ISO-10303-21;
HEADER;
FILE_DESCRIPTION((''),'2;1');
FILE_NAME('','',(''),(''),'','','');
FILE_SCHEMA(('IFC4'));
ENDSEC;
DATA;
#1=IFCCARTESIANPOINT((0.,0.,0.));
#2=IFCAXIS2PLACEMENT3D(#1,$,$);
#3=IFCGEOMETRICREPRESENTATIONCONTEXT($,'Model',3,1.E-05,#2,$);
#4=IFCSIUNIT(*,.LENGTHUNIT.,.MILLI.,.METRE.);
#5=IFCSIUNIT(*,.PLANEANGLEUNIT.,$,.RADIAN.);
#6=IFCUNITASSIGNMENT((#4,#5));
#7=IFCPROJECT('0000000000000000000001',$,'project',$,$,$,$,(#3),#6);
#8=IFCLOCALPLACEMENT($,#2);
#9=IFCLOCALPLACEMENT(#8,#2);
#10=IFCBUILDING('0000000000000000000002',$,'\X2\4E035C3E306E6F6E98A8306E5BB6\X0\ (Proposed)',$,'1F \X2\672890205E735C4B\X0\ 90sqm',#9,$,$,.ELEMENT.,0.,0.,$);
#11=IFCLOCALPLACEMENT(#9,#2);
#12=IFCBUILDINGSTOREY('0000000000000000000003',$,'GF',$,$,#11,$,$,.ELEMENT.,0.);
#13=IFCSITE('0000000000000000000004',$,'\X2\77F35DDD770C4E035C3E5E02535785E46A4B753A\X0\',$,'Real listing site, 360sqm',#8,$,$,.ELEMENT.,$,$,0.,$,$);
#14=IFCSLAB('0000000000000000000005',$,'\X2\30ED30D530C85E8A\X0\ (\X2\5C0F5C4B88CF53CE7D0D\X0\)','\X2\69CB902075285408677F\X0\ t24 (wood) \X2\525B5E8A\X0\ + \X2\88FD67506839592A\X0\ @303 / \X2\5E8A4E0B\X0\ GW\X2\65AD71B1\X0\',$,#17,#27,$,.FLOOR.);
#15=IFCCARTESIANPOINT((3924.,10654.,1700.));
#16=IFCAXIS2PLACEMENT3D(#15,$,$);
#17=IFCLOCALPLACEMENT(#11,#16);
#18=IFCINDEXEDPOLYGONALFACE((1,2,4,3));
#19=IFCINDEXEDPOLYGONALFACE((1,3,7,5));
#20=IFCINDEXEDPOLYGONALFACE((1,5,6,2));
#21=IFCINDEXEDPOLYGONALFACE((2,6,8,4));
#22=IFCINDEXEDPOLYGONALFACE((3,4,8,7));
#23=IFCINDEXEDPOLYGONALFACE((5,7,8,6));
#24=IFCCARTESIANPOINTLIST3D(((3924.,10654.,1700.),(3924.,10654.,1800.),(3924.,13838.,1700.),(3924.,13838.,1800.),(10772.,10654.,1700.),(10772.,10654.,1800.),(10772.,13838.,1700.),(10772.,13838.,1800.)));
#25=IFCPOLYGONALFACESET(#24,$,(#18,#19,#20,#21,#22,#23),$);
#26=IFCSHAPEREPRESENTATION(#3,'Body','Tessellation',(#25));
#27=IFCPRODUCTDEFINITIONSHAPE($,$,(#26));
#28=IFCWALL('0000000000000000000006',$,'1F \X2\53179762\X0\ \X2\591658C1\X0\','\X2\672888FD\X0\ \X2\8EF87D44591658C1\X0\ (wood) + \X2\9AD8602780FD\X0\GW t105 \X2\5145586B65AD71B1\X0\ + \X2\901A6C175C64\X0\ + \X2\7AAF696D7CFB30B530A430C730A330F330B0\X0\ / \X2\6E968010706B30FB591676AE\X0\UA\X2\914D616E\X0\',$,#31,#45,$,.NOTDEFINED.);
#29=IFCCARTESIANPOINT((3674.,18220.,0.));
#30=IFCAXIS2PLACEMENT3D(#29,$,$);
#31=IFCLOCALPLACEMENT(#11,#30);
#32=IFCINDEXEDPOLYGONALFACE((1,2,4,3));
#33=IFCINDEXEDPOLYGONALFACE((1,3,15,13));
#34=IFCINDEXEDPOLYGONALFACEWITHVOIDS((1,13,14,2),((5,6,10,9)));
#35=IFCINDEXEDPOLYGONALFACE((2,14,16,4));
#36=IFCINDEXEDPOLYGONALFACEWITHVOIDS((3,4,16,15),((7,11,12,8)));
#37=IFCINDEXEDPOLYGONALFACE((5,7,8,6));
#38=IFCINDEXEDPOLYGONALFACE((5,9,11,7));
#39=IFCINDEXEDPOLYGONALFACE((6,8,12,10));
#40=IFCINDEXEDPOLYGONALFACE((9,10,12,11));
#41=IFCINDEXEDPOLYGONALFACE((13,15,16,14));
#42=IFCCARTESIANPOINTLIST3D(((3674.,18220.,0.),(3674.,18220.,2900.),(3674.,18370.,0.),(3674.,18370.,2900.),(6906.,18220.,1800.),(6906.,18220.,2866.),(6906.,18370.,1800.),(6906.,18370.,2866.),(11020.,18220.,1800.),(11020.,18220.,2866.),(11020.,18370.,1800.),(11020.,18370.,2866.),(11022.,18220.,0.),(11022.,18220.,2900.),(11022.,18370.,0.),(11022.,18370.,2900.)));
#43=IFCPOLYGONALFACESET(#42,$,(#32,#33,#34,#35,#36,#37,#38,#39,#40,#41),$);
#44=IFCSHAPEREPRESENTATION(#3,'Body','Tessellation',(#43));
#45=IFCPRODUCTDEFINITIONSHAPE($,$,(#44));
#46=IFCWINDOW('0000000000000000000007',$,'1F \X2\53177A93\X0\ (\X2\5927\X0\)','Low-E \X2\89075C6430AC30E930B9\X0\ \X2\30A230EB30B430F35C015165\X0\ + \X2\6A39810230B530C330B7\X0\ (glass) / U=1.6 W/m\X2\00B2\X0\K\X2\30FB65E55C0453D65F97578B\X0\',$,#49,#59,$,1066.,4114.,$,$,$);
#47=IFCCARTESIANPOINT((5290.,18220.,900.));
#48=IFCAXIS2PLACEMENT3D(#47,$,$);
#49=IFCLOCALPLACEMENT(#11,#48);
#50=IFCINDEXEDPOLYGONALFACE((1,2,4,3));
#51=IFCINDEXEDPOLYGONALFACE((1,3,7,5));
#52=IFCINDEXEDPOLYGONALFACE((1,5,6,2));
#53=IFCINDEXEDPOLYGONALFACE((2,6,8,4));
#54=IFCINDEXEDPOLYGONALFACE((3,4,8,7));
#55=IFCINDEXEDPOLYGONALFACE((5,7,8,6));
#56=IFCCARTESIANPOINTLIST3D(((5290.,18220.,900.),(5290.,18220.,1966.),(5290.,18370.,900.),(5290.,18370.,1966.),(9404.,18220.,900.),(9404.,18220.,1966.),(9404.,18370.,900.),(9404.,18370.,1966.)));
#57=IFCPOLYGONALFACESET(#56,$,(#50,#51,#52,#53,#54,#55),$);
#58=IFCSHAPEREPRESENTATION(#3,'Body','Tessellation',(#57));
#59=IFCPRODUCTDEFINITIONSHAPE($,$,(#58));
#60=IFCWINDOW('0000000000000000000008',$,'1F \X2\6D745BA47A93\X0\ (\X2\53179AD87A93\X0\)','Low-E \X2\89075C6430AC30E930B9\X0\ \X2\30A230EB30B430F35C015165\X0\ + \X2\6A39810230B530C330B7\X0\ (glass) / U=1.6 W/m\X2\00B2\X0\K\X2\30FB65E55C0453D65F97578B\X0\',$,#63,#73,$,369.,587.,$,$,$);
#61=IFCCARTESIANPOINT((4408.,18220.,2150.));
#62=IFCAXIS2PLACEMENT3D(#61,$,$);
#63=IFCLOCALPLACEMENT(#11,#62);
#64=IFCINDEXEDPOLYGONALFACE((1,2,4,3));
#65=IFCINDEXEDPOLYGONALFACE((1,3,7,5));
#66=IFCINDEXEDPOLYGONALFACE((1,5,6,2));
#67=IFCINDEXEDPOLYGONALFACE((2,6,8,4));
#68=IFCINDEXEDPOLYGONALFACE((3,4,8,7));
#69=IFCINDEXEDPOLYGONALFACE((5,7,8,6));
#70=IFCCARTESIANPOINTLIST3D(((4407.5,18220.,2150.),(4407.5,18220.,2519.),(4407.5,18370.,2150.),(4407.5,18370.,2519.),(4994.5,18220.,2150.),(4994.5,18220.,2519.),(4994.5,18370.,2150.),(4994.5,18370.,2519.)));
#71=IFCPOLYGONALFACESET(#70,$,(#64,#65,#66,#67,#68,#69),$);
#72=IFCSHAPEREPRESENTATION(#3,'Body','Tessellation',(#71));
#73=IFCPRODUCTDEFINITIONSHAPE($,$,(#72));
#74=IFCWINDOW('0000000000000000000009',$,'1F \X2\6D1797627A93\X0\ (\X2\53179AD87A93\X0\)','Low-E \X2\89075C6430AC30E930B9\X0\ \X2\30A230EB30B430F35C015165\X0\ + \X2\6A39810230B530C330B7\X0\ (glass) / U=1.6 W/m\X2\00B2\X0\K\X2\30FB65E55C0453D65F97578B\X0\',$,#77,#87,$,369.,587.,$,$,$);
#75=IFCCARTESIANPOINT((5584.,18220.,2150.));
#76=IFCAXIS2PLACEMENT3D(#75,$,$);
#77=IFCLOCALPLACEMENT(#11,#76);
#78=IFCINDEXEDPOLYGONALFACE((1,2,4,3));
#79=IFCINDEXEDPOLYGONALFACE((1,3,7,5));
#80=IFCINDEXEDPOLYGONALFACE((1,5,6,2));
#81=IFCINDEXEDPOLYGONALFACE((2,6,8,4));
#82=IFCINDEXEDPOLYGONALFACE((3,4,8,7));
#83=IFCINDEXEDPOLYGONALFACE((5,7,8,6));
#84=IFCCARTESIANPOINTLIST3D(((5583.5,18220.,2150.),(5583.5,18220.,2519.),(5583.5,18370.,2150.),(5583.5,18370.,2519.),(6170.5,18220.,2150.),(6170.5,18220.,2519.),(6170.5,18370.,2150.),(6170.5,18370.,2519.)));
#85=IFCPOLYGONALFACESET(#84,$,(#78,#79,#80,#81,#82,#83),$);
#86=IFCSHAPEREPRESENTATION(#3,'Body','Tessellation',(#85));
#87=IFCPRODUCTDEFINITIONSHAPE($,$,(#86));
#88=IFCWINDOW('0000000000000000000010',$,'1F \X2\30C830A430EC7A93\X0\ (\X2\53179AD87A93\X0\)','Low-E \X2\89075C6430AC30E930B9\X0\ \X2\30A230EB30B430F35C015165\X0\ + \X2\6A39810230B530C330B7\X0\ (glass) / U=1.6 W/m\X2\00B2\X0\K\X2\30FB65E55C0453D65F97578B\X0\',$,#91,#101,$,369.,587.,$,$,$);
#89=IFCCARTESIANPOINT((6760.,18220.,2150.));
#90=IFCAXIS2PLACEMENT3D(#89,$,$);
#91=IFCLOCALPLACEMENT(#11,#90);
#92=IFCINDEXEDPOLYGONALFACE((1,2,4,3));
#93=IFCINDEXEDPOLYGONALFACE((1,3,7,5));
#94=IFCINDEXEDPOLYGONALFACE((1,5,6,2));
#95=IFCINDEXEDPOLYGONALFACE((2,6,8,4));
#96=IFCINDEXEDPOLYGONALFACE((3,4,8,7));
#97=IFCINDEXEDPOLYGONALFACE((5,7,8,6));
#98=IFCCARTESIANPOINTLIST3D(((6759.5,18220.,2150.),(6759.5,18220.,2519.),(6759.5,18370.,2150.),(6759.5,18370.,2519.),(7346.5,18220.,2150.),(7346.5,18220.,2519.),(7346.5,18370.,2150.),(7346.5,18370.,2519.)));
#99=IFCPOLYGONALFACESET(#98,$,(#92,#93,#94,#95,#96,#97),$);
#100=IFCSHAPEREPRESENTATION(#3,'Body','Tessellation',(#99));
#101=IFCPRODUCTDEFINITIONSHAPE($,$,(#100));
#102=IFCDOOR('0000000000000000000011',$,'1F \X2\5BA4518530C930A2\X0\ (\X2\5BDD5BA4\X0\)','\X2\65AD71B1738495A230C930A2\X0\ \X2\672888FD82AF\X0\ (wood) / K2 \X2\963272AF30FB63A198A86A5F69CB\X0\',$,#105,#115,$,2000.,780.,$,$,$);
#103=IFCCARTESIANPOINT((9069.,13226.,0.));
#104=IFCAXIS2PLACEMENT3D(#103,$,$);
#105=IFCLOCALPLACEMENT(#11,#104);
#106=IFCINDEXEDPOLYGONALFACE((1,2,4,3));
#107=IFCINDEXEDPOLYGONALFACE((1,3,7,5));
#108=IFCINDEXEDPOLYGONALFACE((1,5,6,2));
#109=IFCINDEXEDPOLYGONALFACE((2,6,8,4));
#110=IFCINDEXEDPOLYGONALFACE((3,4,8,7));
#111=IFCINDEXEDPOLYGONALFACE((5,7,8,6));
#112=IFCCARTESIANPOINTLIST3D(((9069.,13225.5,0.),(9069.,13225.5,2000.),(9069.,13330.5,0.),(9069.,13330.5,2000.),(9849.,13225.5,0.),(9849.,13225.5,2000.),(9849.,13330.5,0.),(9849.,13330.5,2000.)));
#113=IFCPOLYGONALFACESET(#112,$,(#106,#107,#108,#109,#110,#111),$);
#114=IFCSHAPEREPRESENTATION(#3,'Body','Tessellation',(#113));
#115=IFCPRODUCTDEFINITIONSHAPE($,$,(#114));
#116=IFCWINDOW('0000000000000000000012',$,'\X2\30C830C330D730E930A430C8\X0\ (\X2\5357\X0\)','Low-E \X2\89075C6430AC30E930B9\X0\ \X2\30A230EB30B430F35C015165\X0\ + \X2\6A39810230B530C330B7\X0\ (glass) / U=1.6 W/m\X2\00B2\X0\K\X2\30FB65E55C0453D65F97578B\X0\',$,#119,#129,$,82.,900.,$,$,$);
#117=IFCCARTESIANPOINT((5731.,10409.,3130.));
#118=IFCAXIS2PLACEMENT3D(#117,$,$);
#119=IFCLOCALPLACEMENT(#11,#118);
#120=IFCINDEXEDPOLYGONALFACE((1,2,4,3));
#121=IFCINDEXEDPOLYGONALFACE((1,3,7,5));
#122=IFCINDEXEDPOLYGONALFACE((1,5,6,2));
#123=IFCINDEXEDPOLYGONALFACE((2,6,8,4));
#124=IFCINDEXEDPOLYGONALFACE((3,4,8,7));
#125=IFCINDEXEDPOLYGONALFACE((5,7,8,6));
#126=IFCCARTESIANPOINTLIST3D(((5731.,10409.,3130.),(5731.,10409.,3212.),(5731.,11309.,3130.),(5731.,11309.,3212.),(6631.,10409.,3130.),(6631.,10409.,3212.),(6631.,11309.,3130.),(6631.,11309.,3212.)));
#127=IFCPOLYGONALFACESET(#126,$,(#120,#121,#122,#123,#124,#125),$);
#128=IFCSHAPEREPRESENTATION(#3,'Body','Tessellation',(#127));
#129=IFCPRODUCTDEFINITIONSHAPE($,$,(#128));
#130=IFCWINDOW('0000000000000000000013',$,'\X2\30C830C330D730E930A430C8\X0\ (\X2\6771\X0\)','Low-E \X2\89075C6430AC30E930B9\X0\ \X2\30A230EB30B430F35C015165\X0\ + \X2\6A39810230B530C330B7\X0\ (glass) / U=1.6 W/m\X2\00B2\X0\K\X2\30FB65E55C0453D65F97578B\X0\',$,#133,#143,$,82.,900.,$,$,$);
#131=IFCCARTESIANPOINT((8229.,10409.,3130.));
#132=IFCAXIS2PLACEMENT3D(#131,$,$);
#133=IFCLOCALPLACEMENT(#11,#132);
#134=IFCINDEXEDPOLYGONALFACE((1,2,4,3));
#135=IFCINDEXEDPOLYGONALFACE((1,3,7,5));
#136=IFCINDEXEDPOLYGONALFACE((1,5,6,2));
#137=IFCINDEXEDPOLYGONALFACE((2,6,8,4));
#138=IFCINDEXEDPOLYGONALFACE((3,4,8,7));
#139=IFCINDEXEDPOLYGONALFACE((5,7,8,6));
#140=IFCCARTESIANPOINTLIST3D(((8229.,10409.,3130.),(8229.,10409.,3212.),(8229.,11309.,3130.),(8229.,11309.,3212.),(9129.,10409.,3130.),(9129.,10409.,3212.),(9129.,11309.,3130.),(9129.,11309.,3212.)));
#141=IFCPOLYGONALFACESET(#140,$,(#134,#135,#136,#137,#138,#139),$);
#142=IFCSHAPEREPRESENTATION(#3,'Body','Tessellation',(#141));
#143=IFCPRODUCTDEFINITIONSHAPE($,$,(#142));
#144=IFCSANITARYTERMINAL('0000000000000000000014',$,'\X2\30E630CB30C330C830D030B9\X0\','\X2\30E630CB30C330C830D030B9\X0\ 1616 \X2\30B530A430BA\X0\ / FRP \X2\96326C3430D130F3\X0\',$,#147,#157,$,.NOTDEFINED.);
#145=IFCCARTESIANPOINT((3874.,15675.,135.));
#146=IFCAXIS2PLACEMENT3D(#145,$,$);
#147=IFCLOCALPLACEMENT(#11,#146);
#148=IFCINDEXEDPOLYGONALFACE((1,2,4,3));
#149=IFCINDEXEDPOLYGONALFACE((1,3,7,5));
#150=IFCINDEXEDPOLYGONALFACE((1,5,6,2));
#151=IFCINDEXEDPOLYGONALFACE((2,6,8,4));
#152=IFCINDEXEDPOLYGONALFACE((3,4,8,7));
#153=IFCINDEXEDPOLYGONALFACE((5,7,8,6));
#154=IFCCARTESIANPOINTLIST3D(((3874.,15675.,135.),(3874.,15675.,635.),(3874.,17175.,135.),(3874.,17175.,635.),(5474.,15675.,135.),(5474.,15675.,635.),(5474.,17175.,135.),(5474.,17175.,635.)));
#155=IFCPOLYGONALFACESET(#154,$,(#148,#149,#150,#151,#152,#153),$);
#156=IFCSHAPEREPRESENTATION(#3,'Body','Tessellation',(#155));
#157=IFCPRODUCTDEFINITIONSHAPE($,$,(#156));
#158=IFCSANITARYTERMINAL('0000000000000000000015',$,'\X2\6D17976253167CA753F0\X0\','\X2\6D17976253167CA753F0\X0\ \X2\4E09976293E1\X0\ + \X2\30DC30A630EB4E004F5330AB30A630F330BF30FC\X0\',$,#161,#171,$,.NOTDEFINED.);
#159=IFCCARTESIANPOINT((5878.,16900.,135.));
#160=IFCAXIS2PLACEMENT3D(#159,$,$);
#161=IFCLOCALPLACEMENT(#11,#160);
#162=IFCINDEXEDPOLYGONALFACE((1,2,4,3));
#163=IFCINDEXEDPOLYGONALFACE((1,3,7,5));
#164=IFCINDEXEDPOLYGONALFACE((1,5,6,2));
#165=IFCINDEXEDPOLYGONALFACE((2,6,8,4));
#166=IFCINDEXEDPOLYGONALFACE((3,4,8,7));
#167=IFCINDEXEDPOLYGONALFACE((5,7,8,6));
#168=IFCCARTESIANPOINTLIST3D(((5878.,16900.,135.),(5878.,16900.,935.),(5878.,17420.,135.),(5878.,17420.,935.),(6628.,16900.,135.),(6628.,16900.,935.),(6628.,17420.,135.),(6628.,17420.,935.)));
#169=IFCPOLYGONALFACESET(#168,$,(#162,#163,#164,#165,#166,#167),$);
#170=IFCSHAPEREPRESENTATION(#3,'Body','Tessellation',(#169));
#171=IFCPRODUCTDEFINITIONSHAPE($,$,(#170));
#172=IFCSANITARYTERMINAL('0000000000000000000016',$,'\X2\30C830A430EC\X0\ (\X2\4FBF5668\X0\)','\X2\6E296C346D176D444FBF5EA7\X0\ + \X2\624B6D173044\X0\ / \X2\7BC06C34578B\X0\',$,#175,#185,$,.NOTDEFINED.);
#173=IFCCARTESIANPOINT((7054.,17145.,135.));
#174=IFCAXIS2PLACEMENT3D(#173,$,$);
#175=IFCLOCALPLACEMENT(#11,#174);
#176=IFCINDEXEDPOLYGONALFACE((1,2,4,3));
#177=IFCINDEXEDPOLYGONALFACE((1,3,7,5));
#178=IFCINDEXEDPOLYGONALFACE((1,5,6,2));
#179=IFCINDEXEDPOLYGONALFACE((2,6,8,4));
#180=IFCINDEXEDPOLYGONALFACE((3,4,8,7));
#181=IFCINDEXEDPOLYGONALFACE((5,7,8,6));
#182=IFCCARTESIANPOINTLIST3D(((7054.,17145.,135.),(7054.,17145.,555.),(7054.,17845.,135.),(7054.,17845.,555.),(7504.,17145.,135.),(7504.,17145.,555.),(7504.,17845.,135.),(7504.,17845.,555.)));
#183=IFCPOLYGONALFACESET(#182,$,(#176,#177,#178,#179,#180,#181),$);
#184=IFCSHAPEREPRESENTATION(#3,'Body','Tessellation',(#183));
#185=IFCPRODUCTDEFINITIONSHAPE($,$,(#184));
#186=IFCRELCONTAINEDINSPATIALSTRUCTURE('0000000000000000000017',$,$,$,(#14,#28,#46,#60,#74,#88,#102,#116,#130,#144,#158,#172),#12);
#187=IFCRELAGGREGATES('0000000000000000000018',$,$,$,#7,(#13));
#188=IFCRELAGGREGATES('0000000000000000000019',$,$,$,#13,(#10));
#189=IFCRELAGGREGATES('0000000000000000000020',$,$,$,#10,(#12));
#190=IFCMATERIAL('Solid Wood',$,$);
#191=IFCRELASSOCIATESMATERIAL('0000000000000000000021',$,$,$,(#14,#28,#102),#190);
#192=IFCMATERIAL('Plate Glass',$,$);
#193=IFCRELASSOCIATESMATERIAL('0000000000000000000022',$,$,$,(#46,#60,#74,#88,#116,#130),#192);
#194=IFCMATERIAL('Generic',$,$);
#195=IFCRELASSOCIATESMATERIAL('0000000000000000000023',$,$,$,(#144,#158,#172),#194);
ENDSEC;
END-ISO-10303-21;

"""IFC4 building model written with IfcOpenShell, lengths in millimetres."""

from ifc_helpers import new_model, si_unit, frame, frame_2d, origin, place, context, project, spatial, rectangle, extrude, material, element, fill, save


model = new_model("IFC4")

# Units and contexts
model_context = context("Model", 3, precision=1e-05, world=origin())
ifc_project = project(units=[si_unit("LENGTHUNIT", "METRE", prefix="MILLI"), si_unit("PLANEANGLEUNIT", "RADIAN")], contexts=[model_context])

# Site, building, storey
site_placement = place(None, origin())
site = spatial("IfcSite", under=ifc_project, at=site_placement, Name="石川県七尾市南藤橋町", ObjectType="Real listing site, 360sqm", CompositionType="ELEMENT", RefElevation=0.0)
building_placement = place(site_placement, origin())
building = spatial("IfcBuilding", under=site, at=building_placement, Name="七尾の潮風の家 (Proposed)", ObjectType="1F 木造平屋 90sqm", CompositionType="ELEMENT", ElevationOfRefHeight=0.0, ElevationOfTerrain=0.0)
storey_placement = place(building_placement, origin())
storey = spatial("IfcBuildingStorey", under=building, at=storey_placement, Name="GF", CompositionType="ELEMENT", Elevation=0.0)

# Slab
ifc_material_1 = material(Name="Solid Wood")
slab_placement = place(storey_placement, frame((3924.0, 10654.0, 1700.0)))
element("IfcSlab", 1, at=slab_placement, inside=storey, material=ifc_material_1, Name="ロフト床 (小屋裏収納)", Description="構造用合板 t24 (wood) 剛床 + 製材根太 @303 / 床下 GW断熱", PredefinedType="FLOOR", context=model_context, shape_type="SweptSolid", body=[
    extrude(rectangle(XDim=6848.0, YDim=3184.0, at=frame_2d((3424.0, 1592.0))), frame((3924.0, 10654.0, 1700.0)), (0.0, 0.0, 1.0), 100.0),
])

# Wall, openings, windows
wall_1_placement = place(storey_placement, frame((3674.0, 18220.0, 0.0)))
wall_1 = element("IfcWall", 2, at=wall_1_placement, inside=storey, material=ifc_material_1, Name="1F 北面 外壁", Description="木製 軸組外壁 (wood) + 高性能GW t105 充填断熱 + 通気層 + 窯業系サイディング / 準耐火・外皮UA配慮", PredefinedType="NOTDEFINED", context=model_context, shape_type="SweptSolid", body=[
    extrude(rectangle(XDim=7348.0, YDim=150.0, at=frame_2d((3674.0, 75.0))), frame((3674.0, 18220.0, 0.0)), (0.0, 0.0, 1.0), 2900.0),
])
opening_1_placement = place(storey_placement, frame((5290.0, 18220.0, 900.0)))
opening_1 = element("IfcOpeningElement", 3, at=opening_1_placement, cuts=wall_1, PredefinedType="NOTDEFINED", context=model_context, shape_type="SweptSolid", body=[
    extrude(rectangle(XDim=4114.0, YDim=150.0, at=frame_2d((2057.0, 75.0))), frame((5290.0, 18220.0, 900.0)), (0.0, 0.0, 1.0), 1066.0),
])
opening_2_placement = place(storey_placement, frame((4408.0, 18220.0, 2150.0)))
opening_2 = element("IfcOpeningElement", 4, at=opening_2_placement, cuts=wall_1, PredefinedType="NOTDEFINED", context=model_context, shape_type="SweptSolid", body=[
    extrude(rectangle(XDim=587.0, YDim=150.0, at=frame_2d((293.0, 75.0))), frame((4408.0, 18220.0, 2150.0)), (0.0, 0.0, 1.0), 369.0),
])
opening_3_placement = place(storey_placement, frame((5584.0, 18220.0, 2150.0)))
opening_3 = element("IfcOpeningElement", 5, at=opening_3_placement, cuts=wall_1, PredefinedType="NOTDEFINED", context=model_context, shape_type="SweptSolid", body=[
    extrude(rectangle(XDim=587.0, YDim=150.0, at=frame_2d((293.0, 75.0))), frame((5584.0, 18220.0, 2150.0)), (0.0, 0.0, 1.0), 369.0),
])
opening_4_placement = place(storey_placement, frame((6760.0, 18220.0, 2150.0)))
opening_4 = element("IfcOpeningElement", 6, at=opening_4_placement, cuts=wall_1, PredefinedType="NOTDEFINED", context=model_context, shape_type="SweptSolid", body=[
    extrude(rectangle(XDim=587.0, YDim=150.0, at=frame_2d((293.0, 75.0))), frame((6760.0, 18220.0, 2150.0)), (0.0, 0.0, 1.0), 369.0),
])
ifc_material_2 = material(Name="Plate Glass")
window_1_placement = place(storey_placement, frame((5290.0, 18220.0, 900.0)))
window_1 = element("IfcWindow", 7, at=window_1_placement, inside=storey, material=ifc_material_2, Name="1F 北窓 (大)", Description="Low-E 複層ガラス アルゴン封入 + 樹脂サッシ (glass) / U=1.6 W/m²K・日射取得型", OverallHeight=1066.0, OverallWidth=4114.0, context=model_context, shape_type="SweptSolid", body=[
    extrude(rectangle(XDim=4114.0, YDim=150.0, at=frame_2d((2057.0, 75.0))), frame((5290.0, 18220.0, 900.0)), (0.0, 0.0, 1.0), 1066.0),
])
fill(opening_1, window_1)
window_2_placement = place(storey_placement, frame((4408.0, 18220.0, 2150.0)))
window_2 = element("IfcWindow", 8, at=window_2_placement, inside=storey, material=ifc_material_2, Name="1F 浴室窓 (北高窓)", Description="Low-E 複層ガラス アルゴン封入 + 樹脂サッシ (glass) / U=1.6 W/m²K・日射取得型", OverallHeight=369.0, OverallWidth=587.0, context=model_context, shape_type="SweptSolid", body=[
    extrude(rectangle(XDim=587.0, YDim=150.0, at=frame_2d((293.0, 75.0))), frame((4408.0, 18220.0, 2150.0)), (0.0, 0.0, 1.0), 369.0),
])
fill(opening_2, window_2)
window_3_placement = place(storey_placement, frame((5584.0, 18220.0, 2150.0)))
window_3 = element("IfcWindow", 9, at=window_3_placement, inside=storey, material=ifc_material_2, Name="1F 洗面窓 (北高窓)", Description="Low-E 複層ガラス アルゴン封入 + 樹脂サッシ (glass) / U=1.6 W/m²K・日射取得型", OverallHeight=369.0, OverallWidth=587.0, context=model_context, shape_type="SweptSolid", body=[
    extrude(rectangle(XDim=587.0, YDim=150.0, at=frame_2d((293.0, 75.0))), frame((5584.0, 18220.0, 2150.0)), (0.0, 0.0, 1.0), 369.0),
])
fill(opening_3, window_3)
window_4_placement = place(storey_placement, frame((6760.0, 18220.0, 2150.0)))
window_4 = element("IfcWindow", 10, at=window_4_placement, inside=storey, material=ifc_material_2, Name="1F トイレ窓 (北高窓)", Description="Low-E 複層ガラス アルゴン封入 + 樹脂サッシ (glass) / U=1.6 W/m²K・日射取得型", OverallHeight=369.0, OverallWidth=587.0, context=model_context, shape_type="SweptSolid", body=[
    extrude(rectangle(XDim=587.0, YDim=150.0, at=frame_2d((293.0, 75.0))), frame((6760.0, 18220.0, 2150.0)), (0.0, 0.0, 1.0), 369.0),
])
fill(opening_4, window_4)

# Door
door_1_placement = place(storey_placement, frame((9069.0, 13226.0, 0.0)))
element("IfcDoor", 11, at=door_1_placement, inside=storey, material=ifc_material_1, Name="1F 室内ドア (寝室)", Description="断熱玄関ドア 木製芯 (wood) / K2 防犯・採風機構", OverallHeight=2000.0, OverallWidth=780.0, context=model_context, shape_type="SweptSolid", body=[
    extrude(rectangle(XDim=780.0, YDim=105.0, at=frame_2d((390.0, 52.0))), frame((9069.0, 13226.0, 0.0)), (0.0, 0.0, 1.0), 2000.0),
])

# Windows
window_5_placement = place(storey_placement, frame((5731.0, 10409.0, 3130.0)))
element("IfcWindow", 12, at=window_5_placement, inside=storey, material=ifc_material_2, Name="トップライト (南)", Description="Low-E 複層ガラス アルゴン封入 + 樹脂サッシ (glass) / U=1.6 W/m²K・日射取得型", OverallHeight=82.0, OverallWidth=900.0, context=model_context, shape_type="SweptSolid", body=[
    extrude(rectangle(XDim=900.0, YDim=900.0, at=frame_2d((450.0, 450.0))), frame((5731.0, 10409.0, 3130.0)), (0.0, 0.0, 1.0), 82.0),
])
window_6_placement = place(storey_placement, frame((8229.0, 10409.0, 3130.0)))
element("IfcWindow", 13, at=window_6_placement, inside=storey, material=ifc_material_2, Name="トップライト (東)", Description="Low-E 複層ガラス アルゴン封入 + 樹脂サッシ (glass) / U=1.6 W/m²K・日射取得型", OverallHeight=82.0, OverallWidth=900.0, context=model_context, shape_type="SweptSolid", body=[
    extrude(rectangle(XDim=900.0, YDim=900.0, at=frame_2d((450.0, 450.0))), frame((8229.0, 10409.0, 3130.0)), (0.0, 0.0, 1.0), 82.0),
])

# Sanitary terminals
ifc_material_3 = material(Name="Generic")
sanitary_terminal_1_placement = place(storey_placement, frame((3874.0, 15675.0, 135.0)))
element("IfcSanitaryTerminal", 14, at=sanitary_terminal_1_placement, inside=storey, material=ifc_material_3, Name="ユニットバス", Description="ユニットバス 1616 サイズ / FRP 防水パン", PredefinedType="NOTDEFINED", context=model_context, shape_type="SweptSolid", body=[
    extrude(rectangle(XDim=1600.0, YDim=1500.0, at=frame_2d((800.0, 750.0))), frame((3874.0, 15675.0, 135.0)), (0.0, 0.0, 1.0), 500.0),
])
sanitary_terminal_2_placement = place(storey_placement, frame((5878.0, 16900.0, 135.0)))
element("IfcSanitaryTerminal", 15, at=sanitary_terminal_2_placement, inside=storey, material=ifc_material_3, Name="洗面化粧台", Description="洗面化粧台 三面鏡 + ボウル一体カウンター", PredefinedType="NOTDEFINED", context=model_context, shape_type="SweptSolid", body=[
    extrude(rectangle(XDim=750.0, YDim=520.0, at=frame_2d((375.0, 260.0))), frame((5878.0, 16900.0, 135.0)), (0.0, 0.0, 1.0), 800.0),
])
sanitary_terminal_3_placement = place(storey_placement, frame((7054.0, 17145.0, 135.0)))
element("IfcSanitaryTerminal", 16, at=sanitary_terminal_3_placement, inside=storey, material=ifc_material_3, Name="トイレ (便器)", Description="温水洗浄便座 + 手洗い / 節水型", PredefinedType="NOTDEFINED", context=model_context, shape_type="SweptSolid", body=[
    extrude(rectangle(XDim=450.0, YDim=700.0, at=frame_2d((225.0, 350.0))), frame((7054.0, 17145.0, 135.0)), (0.0, 0.0, 1.0), 420.0),
])

save(model, "model.ifc")
